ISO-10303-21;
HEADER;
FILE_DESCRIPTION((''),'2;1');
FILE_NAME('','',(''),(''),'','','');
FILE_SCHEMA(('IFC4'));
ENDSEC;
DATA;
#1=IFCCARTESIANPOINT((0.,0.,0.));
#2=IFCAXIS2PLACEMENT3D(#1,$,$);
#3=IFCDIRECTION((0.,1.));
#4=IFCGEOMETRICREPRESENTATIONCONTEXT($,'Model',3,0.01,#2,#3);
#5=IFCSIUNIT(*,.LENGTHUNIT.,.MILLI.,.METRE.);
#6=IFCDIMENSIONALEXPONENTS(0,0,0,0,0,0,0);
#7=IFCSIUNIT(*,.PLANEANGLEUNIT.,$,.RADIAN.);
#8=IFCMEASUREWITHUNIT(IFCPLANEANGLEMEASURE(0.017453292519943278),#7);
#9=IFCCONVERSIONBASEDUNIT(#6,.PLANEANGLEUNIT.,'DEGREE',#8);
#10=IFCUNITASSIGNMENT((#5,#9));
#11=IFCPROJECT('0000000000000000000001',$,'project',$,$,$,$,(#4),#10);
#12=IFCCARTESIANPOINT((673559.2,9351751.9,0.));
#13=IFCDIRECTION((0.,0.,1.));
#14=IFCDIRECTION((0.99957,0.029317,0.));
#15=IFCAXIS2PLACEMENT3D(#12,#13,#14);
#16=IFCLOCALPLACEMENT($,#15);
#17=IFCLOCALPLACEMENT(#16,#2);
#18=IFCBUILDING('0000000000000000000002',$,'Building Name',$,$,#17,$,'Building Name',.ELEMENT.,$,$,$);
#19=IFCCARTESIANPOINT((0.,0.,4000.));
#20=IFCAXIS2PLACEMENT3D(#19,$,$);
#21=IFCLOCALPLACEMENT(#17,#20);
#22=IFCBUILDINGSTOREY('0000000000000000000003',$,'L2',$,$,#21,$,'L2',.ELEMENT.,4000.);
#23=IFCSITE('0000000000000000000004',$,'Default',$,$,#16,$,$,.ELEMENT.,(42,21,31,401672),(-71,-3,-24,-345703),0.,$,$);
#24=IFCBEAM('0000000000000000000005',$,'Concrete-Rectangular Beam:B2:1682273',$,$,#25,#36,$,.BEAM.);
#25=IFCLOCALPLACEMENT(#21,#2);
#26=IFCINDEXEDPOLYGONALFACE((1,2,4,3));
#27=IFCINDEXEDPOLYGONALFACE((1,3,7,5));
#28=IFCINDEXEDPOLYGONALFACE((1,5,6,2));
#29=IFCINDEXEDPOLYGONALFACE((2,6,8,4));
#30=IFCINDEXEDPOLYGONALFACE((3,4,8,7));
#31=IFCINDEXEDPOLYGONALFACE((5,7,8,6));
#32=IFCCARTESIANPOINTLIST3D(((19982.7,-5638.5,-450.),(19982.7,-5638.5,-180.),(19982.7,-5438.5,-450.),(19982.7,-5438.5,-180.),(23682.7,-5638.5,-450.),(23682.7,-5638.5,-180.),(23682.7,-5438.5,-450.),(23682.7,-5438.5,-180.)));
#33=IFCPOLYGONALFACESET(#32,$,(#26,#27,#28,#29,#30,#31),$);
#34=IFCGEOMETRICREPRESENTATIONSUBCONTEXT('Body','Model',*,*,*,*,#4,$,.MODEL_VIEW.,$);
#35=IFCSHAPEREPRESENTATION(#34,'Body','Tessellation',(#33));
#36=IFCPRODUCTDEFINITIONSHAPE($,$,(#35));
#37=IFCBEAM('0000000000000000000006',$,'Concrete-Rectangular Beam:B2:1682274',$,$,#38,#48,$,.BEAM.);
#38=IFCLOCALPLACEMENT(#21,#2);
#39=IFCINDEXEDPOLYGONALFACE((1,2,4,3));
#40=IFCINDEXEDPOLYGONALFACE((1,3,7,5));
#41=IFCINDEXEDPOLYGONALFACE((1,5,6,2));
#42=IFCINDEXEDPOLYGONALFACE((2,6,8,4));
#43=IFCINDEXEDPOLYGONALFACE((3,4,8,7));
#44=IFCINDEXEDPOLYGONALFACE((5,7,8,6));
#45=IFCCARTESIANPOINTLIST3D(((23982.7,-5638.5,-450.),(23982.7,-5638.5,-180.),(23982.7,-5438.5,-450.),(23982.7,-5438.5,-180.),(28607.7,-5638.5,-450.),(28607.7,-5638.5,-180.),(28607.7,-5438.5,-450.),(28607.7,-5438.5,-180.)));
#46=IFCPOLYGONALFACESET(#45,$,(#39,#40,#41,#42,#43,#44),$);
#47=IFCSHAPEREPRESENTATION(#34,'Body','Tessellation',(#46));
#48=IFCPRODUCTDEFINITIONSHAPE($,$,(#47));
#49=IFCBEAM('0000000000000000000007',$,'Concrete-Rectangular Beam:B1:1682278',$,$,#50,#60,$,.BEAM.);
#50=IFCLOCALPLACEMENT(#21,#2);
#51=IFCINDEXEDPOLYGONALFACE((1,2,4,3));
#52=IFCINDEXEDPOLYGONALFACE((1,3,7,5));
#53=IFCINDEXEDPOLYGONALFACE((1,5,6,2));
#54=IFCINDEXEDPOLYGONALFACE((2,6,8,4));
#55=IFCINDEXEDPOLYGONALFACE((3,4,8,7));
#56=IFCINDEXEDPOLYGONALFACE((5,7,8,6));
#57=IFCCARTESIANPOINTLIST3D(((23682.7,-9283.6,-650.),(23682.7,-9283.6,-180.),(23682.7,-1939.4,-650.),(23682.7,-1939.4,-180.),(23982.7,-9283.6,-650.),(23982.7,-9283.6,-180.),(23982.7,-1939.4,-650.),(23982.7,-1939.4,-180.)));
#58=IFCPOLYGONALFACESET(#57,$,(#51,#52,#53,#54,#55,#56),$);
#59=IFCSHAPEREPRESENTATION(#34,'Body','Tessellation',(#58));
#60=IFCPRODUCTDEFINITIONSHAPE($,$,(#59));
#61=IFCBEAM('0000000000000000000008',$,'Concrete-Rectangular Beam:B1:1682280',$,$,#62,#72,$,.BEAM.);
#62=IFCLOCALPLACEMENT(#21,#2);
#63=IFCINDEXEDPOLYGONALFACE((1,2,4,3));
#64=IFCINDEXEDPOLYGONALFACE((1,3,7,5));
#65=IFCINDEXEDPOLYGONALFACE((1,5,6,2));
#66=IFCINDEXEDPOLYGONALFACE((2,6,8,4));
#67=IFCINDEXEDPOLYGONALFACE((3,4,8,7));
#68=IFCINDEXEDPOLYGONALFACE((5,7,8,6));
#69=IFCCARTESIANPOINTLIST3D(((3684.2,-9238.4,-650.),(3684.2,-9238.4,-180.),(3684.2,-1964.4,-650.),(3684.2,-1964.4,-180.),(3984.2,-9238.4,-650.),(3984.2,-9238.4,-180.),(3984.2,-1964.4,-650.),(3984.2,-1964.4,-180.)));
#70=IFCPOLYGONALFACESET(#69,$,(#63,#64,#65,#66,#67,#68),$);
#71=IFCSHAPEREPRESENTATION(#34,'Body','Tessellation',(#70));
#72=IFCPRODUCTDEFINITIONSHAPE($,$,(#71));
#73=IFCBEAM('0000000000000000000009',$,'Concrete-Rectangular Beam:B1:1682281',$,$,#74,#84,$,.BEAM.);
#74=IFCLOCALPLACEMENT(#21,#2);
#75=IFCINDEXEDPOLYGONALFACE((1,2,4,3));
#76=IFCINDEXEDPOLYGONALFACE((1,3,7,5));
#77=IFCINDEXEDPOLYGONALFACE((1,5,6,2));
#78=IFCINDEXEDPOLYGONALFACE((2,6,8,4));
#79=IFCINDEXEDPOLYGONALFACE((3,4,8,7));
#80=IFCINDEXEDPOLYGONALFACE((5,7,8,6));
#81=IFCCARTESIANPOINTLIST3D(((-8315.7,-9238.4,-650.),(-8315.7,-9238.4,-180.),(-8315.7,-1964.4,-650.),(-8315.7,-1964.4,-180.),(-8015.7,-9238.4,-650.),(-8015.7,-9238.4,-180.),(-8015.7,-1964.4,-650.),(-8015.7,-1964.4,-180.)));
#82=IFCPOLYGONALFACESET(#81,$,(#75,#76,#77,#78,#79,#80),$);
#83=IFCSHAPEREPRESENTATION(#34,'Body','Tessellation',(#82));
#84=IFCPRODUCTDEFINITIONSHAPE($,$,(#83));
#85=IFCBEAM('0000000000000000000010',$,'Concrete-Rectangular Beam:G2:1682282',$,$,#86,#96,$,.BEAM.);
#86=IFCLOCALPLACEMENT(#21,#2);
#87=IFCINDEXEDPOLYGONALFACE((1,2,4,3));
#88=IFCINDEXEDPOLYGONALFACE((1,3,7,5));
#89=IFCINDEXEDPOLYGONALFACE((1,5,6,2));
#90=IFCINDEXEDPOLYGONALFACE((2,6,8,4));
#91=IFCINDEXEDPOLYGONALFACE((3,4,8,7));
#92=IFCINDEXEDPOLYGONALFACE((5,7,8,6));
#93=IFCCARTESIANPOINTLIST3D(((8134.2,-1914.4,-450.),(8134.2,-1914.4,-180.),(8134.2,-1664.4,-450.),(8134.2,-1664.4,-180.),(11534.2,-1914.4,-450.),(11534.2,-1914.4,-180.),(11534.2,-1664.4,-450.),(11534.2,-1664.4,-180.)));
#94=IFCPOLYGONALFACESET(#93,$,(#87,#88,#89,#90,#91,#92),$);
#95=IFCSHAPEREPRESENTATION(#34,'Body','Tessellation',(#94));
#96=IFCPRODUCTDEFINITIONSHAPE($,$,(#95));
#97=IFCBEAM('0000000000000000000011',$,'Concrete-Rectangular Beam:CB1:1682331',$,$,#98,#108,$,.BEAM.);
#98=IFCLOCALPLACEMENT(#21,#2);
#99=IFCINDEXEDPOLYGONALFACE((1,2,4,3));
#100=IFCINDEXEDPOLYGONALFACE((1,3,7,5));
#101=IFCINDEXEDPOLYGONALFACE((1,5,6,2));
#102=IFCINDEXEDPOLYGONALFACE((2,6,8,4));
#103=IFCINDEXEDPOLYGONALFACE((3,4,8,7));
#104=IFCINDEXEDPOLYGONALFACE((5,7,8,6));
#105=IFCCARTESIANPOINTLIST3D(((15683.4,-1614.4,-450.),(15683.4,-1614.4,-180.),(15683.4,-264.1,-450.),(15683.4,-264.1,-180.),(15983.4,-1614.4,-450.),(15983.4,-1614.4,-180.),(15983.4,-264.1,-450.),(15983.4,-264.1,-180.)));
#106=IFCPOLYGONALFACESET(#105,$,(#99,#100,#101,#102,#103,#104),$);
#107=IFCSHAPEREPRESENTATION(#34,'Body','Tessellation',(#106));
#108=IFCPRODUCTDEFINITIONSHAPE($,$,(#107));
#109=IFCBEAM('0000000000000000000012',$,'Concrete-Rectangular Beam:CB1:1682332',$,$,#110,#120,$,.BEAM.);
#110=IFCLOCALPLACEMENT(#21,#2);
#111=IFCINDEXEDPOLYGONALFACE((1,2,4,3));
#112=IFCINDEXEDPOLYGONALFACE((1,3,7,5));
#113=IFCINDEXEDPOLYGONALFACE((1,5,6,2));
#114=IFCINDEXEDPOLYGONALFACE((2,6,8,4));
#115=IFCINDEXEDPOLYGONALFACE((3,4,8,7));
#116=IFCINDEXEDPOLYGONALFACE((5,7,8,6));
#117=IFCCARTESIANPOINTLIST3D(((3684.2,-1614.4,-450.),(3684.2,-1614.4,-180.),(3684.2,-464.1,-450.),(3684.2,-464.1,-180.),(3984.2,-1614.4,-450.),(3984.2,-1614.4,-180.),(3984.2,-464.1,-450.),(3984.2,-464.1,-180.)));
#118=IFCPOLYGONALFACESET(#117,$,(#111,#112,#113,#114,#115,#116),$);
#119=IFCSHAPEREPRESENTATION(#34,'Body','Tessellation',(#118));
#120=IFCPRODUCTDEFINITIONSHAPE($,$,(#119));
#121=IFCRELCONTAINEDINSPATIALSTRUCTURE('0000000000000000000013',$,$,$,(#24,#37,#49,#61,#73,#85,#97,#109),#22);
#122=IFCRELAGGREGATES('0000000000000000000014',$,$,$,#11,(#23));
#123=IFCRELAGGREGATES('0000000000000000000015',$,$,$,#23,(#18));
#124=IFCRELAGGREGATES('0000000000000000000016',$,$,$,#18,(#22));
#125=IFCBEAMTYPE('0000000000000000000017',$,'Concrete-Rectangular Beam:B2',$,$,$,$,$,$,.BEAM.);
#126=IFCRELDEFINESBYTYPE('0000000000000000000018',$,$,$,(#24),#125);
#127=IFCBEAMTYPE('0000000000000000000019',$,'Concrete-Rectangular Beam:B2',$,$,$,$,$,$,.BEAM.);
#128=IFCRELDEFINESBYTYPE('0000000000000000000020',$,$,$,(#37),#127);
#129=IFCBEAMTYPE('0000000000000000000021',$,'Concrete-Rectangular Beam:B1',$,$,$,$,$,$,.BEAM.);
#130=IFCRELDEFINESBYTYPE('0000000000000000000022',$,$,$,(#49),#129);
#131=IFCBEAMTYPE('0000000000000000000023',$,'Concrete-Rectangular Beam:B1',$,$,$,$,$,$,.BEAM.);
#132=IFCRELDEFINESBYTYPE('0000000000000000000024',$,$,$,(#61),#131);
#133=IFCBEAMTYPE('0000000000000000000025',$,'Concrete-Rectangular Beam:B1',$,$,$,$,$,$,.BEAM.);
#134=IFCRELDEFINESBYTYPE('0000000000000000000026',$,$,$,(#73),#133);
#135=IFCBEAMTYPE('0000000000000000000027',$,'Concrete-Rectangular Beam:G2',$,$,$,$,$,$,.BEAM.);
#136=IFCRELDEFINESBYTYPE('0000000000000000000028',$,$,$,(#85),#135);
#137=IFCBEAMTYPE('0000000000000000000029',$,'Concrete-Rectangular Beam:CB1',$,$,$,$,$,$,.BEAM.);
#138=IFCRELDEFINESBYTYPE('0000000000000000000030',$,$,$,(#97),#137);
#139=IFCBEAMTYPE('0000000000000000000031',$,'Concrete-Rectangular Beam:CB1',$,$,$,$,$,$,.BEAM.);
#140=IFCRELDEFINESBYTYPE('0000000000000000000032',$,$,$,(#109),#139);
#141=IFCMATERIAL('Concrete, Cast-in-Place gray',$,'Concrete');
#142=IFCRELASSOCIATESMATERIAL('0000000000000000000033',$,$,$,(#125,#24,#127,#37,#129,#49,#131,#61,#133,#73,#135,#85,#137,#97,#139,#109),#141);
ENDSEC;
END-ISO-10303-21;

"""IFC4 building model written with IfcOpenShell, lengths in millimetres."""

from ifc_helpers import new_model, entity, si_unit, converted_unit, direction, frame, origin, place, context, subcontext, project, spatial, indexed_curve, outline, extrude, source, transform, mapped, material, type_object, type_shapes, element, save


model = new_model("IFC4")

# Units and contexts
model_context = context("Model", 3, precision=0.01, world=origin(), true_north=direction((0.0, 1.0)))
body_context = subcontext(model_context, "Body", "Model", "MODEL_VIEW")
ifc_project = project(units=[si_unit("LENGTHUNIT", "METRE", prefix="MILLI"), converted_unit("PLANEANGLEUNIT", "DEGREE", entity("IfcPlaneAngleMeasure", 0.017453292519943278), si_unit("PLANEANGLEUNIT", "RADIAN"), dimensions=[0, 0, 0, 0, 0, 0, 0])], contexts=[model_context])

# Site, building, storey
site_placement = place(None, frame((673559.2, 9351751.9, 0.0), z_axis=(0.0, 0.0, 1.0), x_axis=(0.99957, 0.029317, 0.0)))
site = spatial("IfcSite", under=ifc_project, at=site_placement, Name="Default", CompositionType="ELEMENT", RefLatitude=(42, 21, 31, 401672), RefLongitude=(-71, -3, -24, -345703), RefElevation=0.0)
building_placement = place(site_placement, origin())
building = spatial("IfcBuilding", under=site, at=building_placement, Name="Building Name", LongName="Building Name", CompositionType="ELEMENT")
storey_placement = place(building_placement, frame((0.0, 0.0, 4000.0)))
storey = spatial("IfcBuildingStorey", under=building, at=storey_placement, Name="L2", LongName="L2", CompositionType="ELEMENT", Elevation=4000.0)

# Shared definitions
ifc_material = material(Name="Concrete, Cast-in-Place gray", Category="Concrete")

# Beams
beam_type_1 = type_object("IfcBeamType", Name="Concrete-Rectangular Beam:B2", PredefinedType="BEAM", material=ifc_material)
shared_shape_1 = source(origin(), body_context, "Body", "SweptSolid", [
    extrude(outline(indexed_curve([(-135.0, -100.0), (135.0, -100.0), (135.0, 100.0), (-135.0, 100.0), (-135.0, -100.0)], self_intersect=False)), frame((19982.7, -5538.5, 3685.0), z_axis=(1.0, 0.0, 0.0), x_axis=(0.0, 0.0, -1.0)), (0.0, 0.0, 1.0), 3700.0),
])
type_shapes(beam_type_1, [shared_shape_1])
beam_1_placement = place(storey_placement, frame((0.0, 0.0, -4000.0)))
element("IfcBeam", 1, at=beam_1_placement, inside=storey, type_object=beam_type_1, material=ifc_material, Name="Concrete-Rectangular Beam:B2:1682273", PredefinedType="BEAM", context=body_context, shape_type="MappedRepresentation", body=[
    mapped(shared_shape_1, transform((0.0, 0.0, 0.0), scale=1.0)),
])
beam_type_2 = type_object("IfcBeamType", Name="Concrete-Rectangular Beam:B2", PredefinedType="BEAM", material=ifc_material)
shared_shape_2 = source(origin(), body_context, "Body", "SweptSolid", [
    extrude(outline(indexed_curve([(-135.0, -100.0), (135.0, -100.0), (135.0, 100.0), (-135.0, 100.0), (-135.0, -100.0)], self_intersect=False)), frame((23982.7, -5538.5, 3685.0), z_axis=(1.0, 0.0, 0.0), x_axis=(0.0, 0.0, -1.0)), (0.0, 0.0, 1.0), 4625.0),
])
type_shapes(beam_type_2, [shared_shape_2])
beam_2_placement = place(storey_placement, frame((0.0, 0.0, -4000.0)))
element("IfcBeam", 2, at=beam_2_placement, inside=storey, type_object=beam_type_2, material=ifc_material, Name="Concrete-Rectangular Beam:B2:1682274", PredefinedType="BEAM", context=body_context, shape_type="MappedRepresentation", body=[
    mapped(shared_shape_2, transform((0.0, 0.0, 0.0), scale=1.0)),
])
beam_type_3 = type_object("IfcBeamType", Name="Concrete-Rectangular Beam:B1", PredefinedType="BEAM", material=ifc_material)
shared_shape_3 = source(origin(), body_context, "Body", "SweptSolid", [
    extrude(outline(indexed_curve([(-150.0, -235.0), (150.0, -235.0), (150.0, 235.0), (-150.0, 235.0), (-150.0, -235.0)], self_intersect=False)), frame((23832.7, -9283.6, 3585.0), z_axis=(0.0, 1.0, 0.0), x_axis=(-1.0, 0.0, 0.0)), (0.0, 0.0, 1.0), 7344.1),
])
type_shapes(beam_type_3, [shared_shape_3])
beam_3_placement = place(storey_placement, frame((0.0, 0.0, -4000.0)))
element("IfcBeam", 3, at=beam_3_placement, inside=storey, type_object=beam_type_3, material=ifc_material, Name="Concrete-Rectangular Beam:B1:1682278", PredefinedType="BEAM", context=body_context, shape_type="MappedRepresentation", body=[
    mapped(shared_shape_3, transform((0.0, 0.0, 0.0), scale=1.0)),
])
beam_type_4 = type_object("IfcBeamType", Name="Concrete-Rectangular Beam:B1", PredefinedType="BEAM", material=ifc_material)
shared_shape_4 = source(origin(), body_context, "Body", "SweptSolid", [
    extrude(outline(indexed_curve([(-150.0, -235.0), (150.0, -235.0), (150.0, 235.0), (-150.0, 235.0), (-150.0, -235.0)], self_intersect=False)), frame((3834.2, -9238.4, 3585.0), z_axis=(0.0, 1.0, 0.0), x_axis=(-1.0, 0.0, 0.0)), (0.0, 0.0, 1.0), 7273.9),
])
type_shapes(beam_type_4, [shared_shape_4])
beam_4_placement = place(storey_placement, frame((0.0, 0.0, -4000.0)))
element("IfcBeam", 4, at=beam_4_placement, inside=storey, type_object=beam_type_4, material=ifc_material, Name="Concrete-Rectangular Beam:B1:1682280", PredefinedType="BEAM", context=body_context, shape_type="MappedRepresentation", body=[
    mapped(shared_shape_4, transform((0.0, 0.0, 0.0), scale=1.0)),
])
beam_type_5 = type_object("IfcBeamType", Name="Concrete-Rectangular Beam:B1", PredefinedType="BEAM", material=ifc_material)
shared_shape_5 = source(origin(), body_context, "Body", "SweptSolid", [
    extrude(outline(indexed_curve([(-150.0, -235.0), (150.0, -235.0), (150.0, 235.0), (-150.0, 235.0), (-150.0, -235.0)], self_intersect=False)), frame((-8165.7, -9238.4, 3585.0), z_axis=(0.0, 1.0, 0.0), x_axis=(-1.0, 0.0, 0.0)), (0.0, 0.0, 1.0), 7273.9),
])
type_shapes(beam_type_5, [shared_shape_5])
beam_5_placement = place(storey_placement, frame((0.0, 0.0, -4000.0)))
element("IfcBeam", 5, at=beam_5_placement, inside=storey, type_object=beam_type_5, material=ifc_material, Name="Concrete-Rectangular Beam:B1:1682281", PredefinedType="BEAM", context=body_context, shape_type="MappedRepresentation", body=[
    mapped(shared_shape_5, transform((0.0, 0.0, 0.0), scale=1.0)),
])
beam_type_6 = type_object("IfcBeamType", Name="Concrete-Rectangular Beam:G2", PredefinedType="BEAM", material=ifc_material)
shared_shape_6 = source(origin(), body_context, "Body", "SweptSolid", [
    extrude(outline(indexed_curve([(-135.0, -125.0), (135.0, -125.0), (135.0, 125.0), (-135.0, 125.0), (-135.0, -125.0)], self_intersect=False)), frame((8134.2, -1789.4, 3685.0), z_axis=(1.0, 0.0, 0.0), x_axis=(0.0, 0.0, -1.0)), (0.0, 0.0, 1.0), 3400.0),
])
type_shapes(beam_type_6, [shared_shape_6])
beam_6_placement = place(storey_placement, frame((0.0, 0.0, -4000.0)))
element("IfcBeam", 6, at=beam_6_placement, inside=storey, type_object=beam_type_6, material=ifc_material, Name="Concrete-Rectangular Beam:G2:1682282", PredefinedType="BEAM", context=body_context, shape_type="MappedRepresentation", body=[
    mapped(shared_shape_6, transform((0.0, 0.0, 0.0), scale=1.0)),
])
beam_type_7 = type_object("IfcBeamType", Name="Concrete-Rectangular Beam:CB1", PredefinedType="BEAM", material=ifc_material)
shared_shape_7 = source(origin(), body_context, "Body", "SweptSolid", [
    extrude(outline(indexed_curve([(-150.0, -135.0), (150.0, -135.0), (150.0, 135.0), (-150.0, 135.0), (-150.0, -135.0)], self_intersect=False)), frame((15833.4, -1614.4, 3685.0), z_axis=(0.0, 1.0, 0.0), x_axis=(-1.0, 0.0, 0.0)), (0.0, 0.0, 1.0), 1350.4),
])
type_shapes(beam_type_7, [shared_shape_7])
beam_7_placement = place(storey_placement, frame((0.0, 0.0, -4000.0)))
element("IfcBeam", 7, at=beam_7_placement, inside=storey, type_object=beam_type_7, material=ifc_material, Name="Concrete-Rectangular Beam:CB1:1682331", PredefinedType="BEAM", context=body_context, shape_type="MappedRepresentation", body=[
    mapped(shared_shape_7, transform((0.0, 0.0, 0.0), scale=1.0)),
])
beam_type_8 = type_object("IfcBeamType", Name="Concrete-Rectangular Beam:CB1", PredefinedType="BEAM", material=ifc_material)
shared_shape_8 = source(origin(), body_context, "Body", "SweptSolid", [
    extrude(outline(indexed_curve([(-150.0, -135.0), (150.0, -135.0), (150.0, 135.0), (-150.0, 135.0), (-150.0, -135.0)], self_intersect=False)), frame((3834.2, -1614.4, 3685.0), z_axis=(0.0, 1.0, 0.0), x_axis=(-1.0, 0.0, 0.0)), (0.0, 0.0, 1.0), 1150.4),
])
type_shapes(beam_type_8, [shared_shape_8])
beam_8_placement = place(storey_placement, frame((0.0, 0.0, -4000.0)))
element("IfcBeam", 8, at=beam_8_placement, inside=storey, type_object=beam_type_8, material=ifc_material, Name="Concrete-Rectangular Beam:CB1:1682332", PredefinedType="BEAM", context=body_context, shape_type="MappedRepresentation", body=[
    mapped(shared_shape_8, transform((0.0, 0.0, 0.0), scale=1.0)),
])

save(model, "model.ifc")
